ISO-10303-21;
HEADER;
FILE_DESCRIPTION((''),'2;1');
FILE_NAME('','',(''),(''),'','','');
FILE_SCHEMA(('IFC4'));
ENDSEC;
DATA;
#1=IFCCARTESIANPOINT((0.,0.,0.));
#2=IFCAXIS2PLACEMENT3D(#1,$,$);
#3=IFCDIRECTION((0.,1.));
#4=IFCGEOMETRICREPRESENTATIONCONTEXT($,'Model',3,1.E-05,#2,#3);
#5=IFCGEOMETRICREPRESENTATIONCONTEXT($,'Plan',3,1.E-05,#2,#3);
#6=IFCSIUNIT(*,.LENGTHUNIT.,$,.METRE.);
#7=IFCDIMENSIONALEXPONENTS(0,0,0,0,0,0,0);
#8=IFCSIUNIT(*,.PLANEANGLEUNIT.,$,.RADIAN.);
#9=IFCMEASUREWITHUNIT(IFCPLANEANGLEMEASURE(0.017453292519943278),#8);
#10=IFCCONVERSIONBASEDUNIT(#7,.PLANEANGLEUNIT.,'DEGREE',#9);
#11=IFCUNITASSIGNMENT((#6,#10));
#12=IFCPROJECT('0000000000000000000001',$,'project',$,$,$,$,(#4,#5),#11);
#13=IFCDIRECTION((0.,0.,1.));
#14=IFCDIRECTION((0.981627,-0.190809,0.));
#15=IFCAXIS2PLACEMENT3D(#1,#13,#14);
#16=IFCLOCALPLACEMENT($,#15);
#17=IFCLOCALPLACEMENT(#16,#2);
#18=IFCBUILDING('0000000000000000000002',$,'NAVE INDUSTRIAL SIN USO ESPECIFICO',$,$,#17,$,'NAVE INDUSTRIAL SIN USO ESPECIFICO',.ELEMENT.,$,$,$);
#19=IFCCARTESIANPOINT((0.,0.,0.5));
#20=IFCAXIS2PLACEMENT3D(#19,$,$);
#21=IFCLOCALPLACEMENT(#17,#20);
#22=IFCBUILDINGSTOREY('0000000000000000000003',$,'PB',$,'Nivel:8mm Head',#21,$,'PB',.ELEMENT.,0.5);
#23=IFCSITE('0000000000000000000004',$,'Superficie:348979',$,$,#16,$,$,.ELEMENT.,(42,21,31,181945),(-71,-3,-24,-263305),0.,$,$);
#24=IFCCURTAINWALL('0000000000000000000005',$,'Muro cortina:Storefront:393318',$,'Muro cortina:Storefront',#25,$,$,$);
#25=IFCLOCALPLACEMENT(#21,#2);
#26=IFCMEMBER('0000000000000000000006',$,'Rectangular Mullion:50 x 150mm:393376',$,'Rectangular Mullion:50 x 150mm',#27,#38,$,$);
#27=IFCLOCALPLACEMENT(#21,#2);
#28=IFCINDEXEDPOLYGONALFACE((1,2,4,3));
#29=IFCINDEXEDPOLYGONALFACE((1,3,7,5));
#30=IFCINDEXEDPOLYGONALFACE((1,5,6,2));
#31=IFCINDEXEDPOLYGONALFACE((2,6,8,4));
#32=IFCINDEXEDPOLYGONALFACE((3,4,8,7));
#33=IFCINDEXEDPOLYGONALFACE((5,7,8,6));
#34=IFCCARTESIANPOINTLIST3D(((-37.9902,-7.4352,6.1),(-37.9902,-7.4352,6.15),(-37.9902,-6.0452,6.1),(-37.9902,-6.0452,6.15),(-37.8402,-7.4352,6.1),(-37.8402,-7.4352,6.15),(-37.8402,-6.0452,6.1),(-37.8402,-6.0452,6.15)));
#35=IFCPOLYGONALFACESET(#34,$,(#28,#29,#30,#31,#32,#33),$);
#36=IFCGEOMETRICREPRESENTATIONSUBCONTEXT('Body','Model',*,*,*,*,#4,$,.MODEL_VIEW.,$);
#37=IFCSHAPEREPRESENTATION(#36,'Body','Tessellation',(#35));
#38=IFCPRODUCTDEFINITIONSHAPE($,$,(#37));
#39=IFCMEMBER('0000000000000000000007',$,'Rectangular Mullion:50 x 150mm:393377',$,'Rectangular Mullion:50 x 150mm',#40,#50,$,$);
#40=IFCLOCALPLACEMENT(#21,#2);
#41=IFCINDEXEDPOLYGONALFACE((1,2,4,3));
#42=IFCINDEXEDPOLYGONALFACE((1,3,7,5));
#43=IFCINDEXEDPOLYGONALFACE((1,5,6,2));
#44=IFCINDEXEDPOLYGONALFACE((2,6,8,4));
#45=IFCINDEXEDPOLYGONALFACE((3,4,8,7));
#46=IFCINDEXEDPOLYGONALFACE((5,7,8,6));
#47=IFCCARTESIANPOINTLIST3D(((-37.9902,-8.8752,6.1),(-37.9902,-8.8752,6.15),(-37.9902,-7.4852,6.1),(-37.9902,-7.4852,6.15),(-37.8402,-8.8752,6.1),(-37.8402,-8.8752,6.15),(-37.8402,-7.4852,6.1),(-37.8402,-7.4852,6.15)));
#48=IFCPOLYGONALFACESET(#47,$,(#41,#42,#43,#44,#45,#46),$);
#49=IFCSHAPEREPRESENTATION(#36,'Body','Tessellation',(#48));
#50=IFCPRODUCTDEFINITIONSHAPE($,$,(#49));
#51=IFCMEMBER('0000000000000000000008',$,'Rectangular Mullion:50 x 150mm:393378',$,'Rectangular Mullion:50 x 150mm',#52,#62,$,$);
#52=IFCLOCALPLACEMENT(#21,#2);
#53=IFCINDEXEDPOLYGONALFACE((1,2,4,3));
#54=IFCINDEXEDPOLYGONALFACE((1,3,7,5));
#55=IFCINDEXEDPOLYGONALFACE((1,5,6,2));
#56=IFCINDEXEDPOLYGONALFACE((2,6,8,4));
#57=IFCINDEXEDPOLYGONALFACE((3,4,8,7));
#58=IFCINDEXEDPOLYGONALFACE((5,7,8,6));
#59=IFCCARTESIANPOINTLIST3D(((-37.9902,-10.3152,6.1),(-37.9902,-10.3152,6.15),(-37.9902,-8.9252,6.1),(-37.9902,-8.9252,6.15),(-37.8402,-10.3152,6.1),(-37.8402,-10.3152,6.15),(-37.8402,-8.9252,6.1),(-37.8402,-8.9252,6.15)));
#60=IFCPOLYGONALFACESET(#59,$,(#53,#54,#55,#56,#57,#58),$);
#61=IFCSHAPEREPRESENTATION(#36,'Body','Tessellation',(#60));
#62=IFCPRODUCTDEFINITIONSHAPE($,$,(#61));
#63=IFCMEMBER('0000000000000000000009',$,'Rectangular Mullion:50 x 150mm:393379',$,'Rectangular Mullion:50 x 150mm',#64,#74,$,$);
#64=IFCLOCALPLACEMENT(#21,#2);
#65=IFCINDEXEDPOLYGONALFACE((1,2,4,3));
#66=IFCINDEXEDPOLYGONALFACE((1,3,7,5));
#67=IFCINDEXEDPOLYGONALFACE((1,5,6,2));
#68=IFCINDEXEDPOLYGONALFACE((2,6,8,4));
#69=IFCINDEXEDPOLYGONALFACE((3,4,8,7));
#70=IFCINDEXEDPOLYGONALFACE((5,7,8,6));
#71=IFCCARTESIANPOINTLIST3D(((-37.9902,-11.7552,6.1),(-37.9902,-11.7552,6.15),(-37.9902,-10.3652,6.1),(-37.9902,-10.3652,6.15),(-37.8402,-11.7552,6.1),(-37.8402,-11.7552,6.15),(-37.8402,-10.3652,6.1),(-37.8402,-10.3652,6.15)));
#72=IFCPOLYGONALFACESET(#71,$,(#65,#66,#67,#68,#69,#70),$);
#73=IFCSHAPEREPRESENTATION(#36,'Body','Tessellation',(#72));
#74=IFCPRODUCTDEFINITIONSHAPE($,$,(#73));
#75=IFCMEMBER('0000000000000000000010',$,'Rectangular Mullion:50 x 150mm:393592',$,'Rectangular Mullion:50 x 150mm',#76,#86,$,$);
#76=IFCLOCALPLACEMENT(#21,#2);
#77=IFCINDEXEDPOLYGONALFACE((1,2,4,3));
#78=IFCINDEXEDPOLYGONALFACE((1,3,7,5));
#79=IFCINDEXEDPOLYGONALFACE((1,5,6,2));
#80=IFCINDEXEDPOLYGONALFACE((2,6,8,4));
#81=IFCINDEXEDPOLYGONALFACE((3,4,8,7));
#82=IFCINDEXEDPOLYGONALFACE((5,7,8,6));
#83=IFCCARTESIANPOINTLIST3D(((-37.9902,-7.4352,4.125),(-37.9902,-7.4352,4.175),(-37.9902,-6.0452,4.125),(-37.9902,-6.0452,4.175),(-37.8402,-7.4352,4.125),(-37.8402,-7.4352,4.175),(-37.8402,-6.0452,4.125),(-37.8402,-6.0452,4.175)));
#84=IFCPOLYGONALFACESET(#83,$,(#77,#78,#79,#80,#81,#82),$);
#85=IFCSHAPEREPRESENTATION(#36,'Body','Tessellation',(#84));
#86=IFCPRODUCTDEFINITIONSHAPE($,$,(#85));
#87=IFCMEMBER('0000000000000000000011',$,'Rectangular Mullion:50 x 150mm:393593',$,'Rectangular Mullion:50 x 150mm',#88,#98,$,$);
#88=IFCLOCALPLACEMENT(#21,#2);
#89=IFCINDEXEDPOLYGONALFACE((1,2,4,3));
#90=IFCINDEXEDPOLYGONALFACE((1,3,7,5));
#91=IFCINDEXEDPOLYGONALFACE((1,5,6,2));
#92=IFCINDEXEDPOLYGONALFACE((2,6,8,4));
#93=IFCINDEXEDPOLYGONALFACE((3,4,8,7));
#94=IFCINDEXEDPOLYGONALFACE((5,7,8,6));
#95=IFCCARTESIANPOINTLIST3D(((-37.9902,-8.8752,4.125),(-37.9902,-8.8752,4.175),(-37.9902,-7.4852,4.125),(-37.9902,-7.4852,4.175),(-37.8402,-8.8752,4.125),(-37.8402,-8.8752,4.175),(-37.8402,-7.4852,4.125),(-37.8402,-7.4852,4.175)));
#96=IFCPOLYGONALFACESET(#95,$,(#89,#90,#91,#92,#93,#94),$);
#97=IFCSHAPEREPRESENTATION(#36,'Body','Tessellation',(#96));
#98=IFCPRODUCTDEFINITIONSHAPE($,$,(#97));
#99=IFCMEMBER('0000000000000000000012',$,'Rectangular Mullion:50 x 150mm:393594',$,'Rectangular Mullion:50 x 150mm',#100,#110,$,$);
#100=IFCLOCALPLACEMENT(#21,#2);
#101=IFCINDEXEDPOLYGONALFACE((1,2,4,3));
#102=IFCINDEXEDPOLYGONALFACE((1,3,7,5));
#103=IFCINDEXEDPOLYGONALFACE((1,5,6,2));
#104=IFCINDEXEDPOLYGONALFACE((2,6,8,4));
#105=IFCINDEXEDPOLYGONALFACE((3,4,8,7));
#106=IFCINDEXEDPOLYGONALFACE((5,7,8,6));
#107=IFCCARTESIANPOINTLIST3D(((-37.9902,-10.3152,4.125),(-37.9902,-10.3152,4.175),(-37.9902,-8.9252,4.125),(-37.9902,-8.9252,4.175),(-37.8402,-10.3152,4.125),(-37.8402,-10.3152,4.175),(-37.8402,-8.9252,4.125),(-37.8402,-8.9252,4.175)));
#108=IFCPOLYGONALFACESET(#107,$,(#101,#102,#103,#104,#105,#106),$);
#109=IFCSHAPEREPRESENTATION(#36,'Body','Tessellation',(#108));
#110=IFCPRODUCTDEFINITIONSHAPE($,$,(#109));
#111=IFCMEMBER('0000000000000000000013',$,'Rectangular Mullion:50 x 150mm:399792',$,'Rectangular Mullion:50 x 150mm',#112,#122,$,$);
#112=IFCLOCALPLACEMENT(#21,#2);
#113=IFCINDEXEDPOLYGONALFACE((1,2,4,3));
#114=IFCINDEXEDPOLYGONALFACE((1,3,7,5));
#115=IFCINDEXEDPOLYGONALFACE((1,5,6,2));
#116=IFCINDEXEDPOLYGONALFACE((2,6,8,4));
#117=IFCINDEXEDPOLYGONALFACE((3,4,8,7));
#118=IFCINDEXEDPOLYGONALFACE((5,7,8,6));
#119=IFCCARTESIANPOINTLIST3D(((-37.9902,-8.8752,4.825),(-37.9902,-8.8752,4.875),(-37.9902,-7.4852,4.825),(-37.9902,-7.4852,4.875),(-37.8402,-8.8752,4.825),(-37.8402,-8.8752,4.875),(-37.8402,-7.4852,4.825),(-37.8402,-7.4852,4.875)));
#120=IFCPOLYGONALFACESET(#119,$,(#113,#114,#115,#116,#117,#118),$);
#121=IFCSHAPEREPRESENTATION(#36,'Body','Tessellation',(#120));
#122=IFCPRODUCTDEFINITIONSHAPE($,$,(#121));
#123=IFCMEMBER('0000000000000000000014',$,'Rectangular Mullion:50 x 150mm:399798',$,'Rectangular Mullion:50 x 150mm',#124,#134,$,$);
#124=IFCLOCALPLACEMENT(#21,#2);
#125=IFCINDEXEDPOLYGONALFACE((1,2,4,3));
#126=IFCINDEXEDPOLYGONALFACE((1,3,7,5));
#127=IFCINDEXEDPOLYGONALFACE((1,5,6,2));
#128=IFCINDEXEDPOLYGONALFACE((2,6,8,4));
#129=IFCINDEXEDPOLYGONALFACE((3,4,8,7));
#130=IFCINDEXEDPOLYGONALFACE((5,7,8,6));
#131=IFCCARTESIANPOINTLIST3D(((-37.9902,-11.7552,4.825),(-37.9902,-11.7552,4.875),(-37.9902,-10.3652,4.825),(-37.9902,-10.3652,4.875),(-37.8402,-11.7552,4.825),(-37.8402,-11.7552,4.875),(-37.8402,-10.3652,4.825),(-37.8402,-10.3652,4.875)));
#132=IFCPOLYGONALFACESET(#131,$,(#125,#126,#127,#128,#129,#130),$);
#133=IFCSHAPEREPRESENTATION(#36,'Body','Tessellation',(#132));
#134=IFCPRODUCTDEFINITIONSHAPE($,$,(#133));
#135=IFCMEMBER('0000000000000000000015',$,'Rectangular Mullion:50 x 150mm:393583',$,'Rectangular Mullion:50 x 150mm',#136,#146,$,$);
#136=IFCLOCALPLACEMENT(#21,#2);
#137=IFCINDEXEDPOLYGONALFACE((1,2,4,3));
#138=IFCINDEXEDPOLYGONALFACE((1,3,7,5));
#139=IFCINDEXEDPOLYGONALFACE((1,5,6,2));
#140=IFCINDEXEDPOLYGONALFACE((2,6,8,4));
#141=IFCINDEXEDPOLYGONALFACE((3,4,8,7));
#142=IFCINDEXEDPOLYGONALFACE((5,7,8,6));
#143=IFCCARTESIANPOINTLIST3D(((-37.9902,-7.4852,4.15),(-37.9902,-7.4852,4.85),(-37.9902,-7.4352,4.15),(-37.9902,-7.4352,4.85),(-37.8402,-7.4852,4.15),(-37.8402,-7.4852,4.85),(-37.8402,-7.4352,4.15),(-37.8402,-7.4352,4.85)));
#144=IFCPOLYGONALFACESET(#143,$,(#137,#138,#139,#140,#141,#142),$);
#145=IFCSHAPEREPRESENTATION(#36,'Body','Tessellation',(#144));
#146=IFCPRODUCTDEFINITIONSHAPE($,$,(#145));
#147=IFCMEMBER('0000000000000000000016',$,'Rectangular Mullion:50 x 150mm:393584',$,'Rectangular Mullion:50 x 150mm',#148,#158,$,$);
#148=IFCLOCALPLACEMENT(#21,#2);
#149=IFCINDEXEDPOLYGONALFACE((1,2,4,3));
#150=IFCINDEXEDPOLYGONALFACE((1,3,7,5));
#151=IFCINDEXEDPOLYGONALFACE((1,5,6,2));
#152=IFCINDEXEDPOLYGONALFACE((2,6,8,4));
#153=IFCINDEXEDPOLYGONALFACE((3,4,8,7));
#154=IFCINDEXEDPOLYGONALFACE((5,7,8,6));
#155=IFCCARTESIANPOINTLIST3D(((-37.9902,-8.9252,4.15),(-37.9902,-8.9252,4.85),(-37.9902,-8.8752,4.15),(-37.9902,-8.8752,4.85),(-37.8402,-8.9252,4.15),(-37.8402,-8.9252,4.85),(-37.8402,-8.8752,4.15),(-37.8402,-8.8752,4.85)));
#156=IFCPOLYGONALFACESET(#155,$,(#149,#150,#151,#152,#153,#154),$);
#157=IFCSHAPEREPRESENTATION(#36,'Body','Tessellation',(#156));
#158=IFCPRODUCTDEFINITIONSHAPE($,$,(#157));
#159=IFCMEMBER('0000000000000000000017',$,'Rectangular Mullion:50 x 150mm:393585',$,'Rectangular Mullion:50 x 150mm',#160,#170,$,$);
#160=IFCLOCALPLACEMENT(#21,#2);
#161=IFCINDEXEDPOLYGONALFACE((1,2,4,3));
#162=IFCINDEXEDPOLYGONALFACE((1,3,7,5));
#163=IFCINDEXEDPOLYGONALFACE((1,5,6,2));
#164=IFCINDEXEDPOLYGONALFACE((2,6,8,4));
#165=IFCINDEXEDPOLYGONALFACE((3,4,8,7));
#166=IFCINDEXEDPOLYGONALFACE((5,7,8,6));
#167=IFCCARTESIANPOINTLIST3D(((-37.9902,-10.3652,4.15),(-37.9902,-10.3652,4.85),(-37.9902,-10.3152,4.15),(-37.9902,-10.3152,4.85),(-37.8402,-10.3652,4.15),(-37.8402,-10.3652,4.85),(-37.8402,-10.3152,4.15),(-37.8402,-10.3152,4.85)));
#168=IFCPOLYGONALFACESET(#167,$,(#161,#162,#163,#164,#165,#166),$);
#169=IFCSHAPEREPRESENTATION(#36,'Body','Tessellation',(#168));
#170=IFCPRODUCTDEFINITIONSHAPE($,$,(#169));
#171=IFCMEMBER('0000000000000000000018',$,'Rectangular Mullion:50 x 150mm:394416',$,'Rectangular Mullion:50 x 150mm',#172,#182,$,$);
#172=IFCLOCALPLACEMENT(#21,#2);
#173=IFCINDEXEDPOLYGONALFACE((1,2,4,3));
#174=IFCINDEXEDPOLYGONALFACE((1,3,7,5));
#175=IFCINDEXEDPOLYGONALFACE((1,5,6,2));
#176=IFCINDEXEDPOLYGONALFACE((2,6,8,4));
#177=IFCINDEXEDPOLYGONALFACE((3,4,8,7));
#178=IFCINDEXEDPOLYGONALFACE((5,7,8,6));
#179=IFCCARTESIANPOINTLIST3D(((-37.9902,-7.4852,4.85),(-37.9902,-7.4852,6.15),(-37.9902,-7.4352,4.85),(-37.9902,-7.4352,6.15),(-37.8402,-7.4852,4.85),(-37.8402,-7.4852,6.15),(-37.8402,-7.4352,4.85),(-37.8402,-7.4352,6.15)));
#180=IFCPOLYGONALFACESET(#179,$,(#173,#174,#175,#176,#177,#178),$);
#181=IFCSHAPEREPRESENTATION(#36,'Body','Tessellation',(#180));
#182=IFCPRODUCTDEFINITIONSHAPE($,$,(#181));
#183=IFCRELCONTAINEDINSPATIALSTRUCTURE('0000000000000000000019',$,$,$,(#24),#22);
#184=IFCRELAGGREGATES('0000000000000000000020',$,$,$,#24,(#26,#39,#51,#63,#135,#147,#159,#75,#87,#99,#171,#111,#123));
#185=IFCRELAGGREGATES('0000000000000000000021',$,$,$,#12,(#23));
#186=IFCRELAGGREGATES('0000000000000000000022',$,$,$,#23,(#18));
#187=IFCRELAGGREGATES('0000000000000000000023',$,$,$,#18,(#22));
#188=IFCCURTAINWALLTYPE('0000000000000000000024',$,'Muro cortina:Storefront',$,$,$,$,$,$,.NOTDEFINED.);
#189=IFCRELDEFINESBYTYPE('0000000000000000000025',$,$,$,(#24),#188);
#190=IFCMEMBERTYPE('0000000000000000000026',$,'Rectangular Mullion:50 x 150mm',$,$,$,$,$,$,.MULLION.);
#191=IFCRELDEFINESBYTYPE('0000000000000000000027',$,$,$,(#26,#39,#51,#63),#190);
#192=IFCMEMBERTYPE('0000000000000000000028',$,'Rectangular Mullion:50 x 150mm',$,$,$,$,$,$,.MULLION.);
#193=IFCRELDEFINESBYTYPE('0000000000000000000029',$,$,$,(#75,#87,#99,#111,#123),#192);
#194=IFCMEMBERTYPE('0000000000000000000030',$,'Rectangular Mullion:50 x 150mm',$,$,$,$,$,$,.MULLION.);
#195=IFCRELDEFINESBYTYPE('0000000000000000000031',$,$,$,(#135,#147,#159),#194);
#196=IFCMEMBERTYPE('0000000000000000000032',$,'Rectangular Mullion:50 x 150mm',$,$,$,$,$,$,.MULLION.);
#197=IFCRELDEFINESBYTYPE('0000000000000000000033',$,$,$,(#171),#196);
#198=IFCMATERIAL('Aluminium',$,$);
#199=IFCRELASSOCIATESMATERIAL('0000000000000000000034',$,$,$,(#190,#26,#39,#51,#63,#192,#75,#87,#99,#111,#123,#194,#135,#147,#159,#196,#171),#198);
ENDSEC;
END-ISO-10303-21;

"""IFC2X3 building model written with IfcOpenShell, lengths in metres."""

from ifc_helpers import new_model, entity, si_unit, converted_unit, direction, frame, origin, origin_2d_with_axis, place, context, subcontext, project, spatial, rectangle, extrude, source, transform, mapped, material, type_object, type_shapes, element, aggregate, save


model = new_model("IFC2X3")

# Units and contexts
model_context = context("Model", 3, precision=1e-05, world=origin(), true_north=direction((0.0, 1.0)))
plan_context = context("Plan", 3, precision=1e-05, world=origin(), true_north=direction((0.0, 1.0)))
body_context = subcontext(model_context, "Body", "Model", "MODEL_VIEW")
ifc_project = project(units=[si_unit("LENGTHUNIT", "METRE"), converted_unit("PLANEANGLEUNIT", "DEGREE", entity("IfcPlaneAngleMeasure", 0.017453292519943278), si_unit("PLANEANGLEUNIT", "RADIAN"), dimensions=[0, 0, 0, 0, 0, 0, 0])], contexts=[model_context, plan_context])

# Site, building, storey
site_placement = place(None, frame((0.0, 0.0, 0.0), z_axis=(0.0, 0.0, 1.0), x_axis=(0.981627, -0.190809, 0.0)))
site = spatial("IfcSite", under=ifc_project, at=site_placement, Name="Superficie:348979", CompositionType="ELEMENT", RefLatitude=(42, 21, 31, 181945), RefLongitude=(-71, -3, -24, -263305), RefElevation=0.0)
building_placement = place(site_placement, origin())
building = spatial("IfcBuilding", under=site, at=building_placement, Name="NAVE INDUSTRIAL SIN USO ESPECIFICO", LongName="NAVE INDUSTRIAL SIN USO ESPECIFICO", CompositionType="ELEMENT")
storey_placement = place(building_placement, frame((0.0, 0.0, 0.5)))
storey = spatial("IfcBuildingStorey", under=building, at=storey_placement, Name="PB", ObjectType="Nivel:8mm Head", LongName="PB", CompositionType="ELEMENT", Elevation=0.5)

# Curtain wall, members
curtain_wall_type = type_object("IfcCurtainWallType", Name="Muro cortina:Storefront", PredefinedType="NOTDEFINED")
curtain_wall_placement = place(storey_placement, frame((0.0, 0.0, -0.5)))
curtain_wall = element("IfcCurtainWall", 1, at=curtain_wall_placement, inside=storey, type_object=curtain_wall_type, Name="Muro cortina:Storefront:393318", ObjectType="Muro cortina:Storefront")
ifc_material_1 = material(Name="Aluminium")
member_type_1 = type_object("IfcMemberType", Name="Rectangular Mullion:50 x 150mm", PredefinedType="MULLION", material=ifc_material_1)
shared_shape_1 = source(origin(), body_context, "Body", "SweptSolid", [
    extrude(rectangle(XDim=0.05, YDim=0.15, at=origin_2d_with_axis()), frame((-0.025, 0.0, -1.39), z_axis=(0.0, 0.0, 1.0), x_axis=(-1.0, 0.0, 0.0)), (0.0, 0.0, 1.0), 1.39),
])
type_shapes(member_type_1, [shared_shape_1])
member_1_placement = place(curtain_wall_placement, frame((-37.9152, -7.4352, 6.65), z_axis=(0.0, -1.0, 0.0), x_axis=(0.0, 0.0, 1.0)))
member_1 = element("IfcMember", 2, at=member_1_placement, type_object=member_type_1, material=ifc_material_1, Name="Rectangular Mullion:50 x 150mm:393376", ObjectType="Rectangular Mullion:50 x 150mm", context=body_context, shape_type="MappedRepresentation", body=[
    mapped(shared_shape_1, transform((0.0, 0.0, 0.0), scale=1.0)),
])
member_2_placement = place(curtain_wall_placement, frame((-37.9152, -8.8752, 6.65), z_axis=(0.0, -1.0, 0.0), x_axis=(0.0, 0.0, 1.0)))
member_2 = element("IfcMember", 3, at=member_2_placement, type_object=member_type_1, material=ifc_material_1, Name="Rectangular Mullion:50 x 150mm:393377", ObjectType="Rectangular Mullion:50 x 150mm", context=body_context, shape_type="MappedRepresentation", body=[
    mapped(shared_shape_1, transform((0.0, 0.0, 0.0), scale=1.0)),
])
member_3_placement = place(curtain_wall_placement, frame((-37.9152, -10.3152, 6.65), z_axis=(0.0, -1.0, 0.0), x_axis=(0.0, 0.0, 1.0)))
member_3 = element("IfcMember", 4, at=member_3_placement, type_object=member_type_1, material=ifc_material_1, Name="Rectangular Mullion:50 x 150mm:393378", ObjectType="Rectangular Mullion:50 x 150mm", context=body_context, shape_type="MappedRepresentation", body=[
    mapped(shared_shape_1, transform((0.0, 0.0, 0.0), scale=1.0)),
])
member_4_placement = place(curtain_wall_placement, frame((-37.9152, -11.7552, 6.65), z_axis=(0.0, -1.0, 0.0), x_axis=(0.0, 0.0, 1.0)))
member_4 = element("IfcMember", 5, at=member_4_placement, type_object=member_type_1, material=ifc_material_1, Name="Rectangular Mullion:50 x 150mm:393379", ObjectType="Rectangular Mullion:50 x 150mm", context=body_context, shape_type="MappedRepresentation", body=[
    mapped(shared_shape_1, transform((0.0, 0.0, 0.0), scale=1.0)),
])
member_type_2 = type_object("IfcMemberType", Name="Rectangular Mullion:50 x 150mm", PredefinedType="MULLION", material=ifc_material_1)
shared_shape_2 = source(origin(), body_context, "Body", "SweptSolid", [
    extrude(rectangle(XDim=0.05, YDim=0.15, at=origin_2d_with_axis()), frame((0.0, 0.0, -1.39), z_axis=(0.0, 0.0, 1.0), x_axis=(-1.0, 0.0, 0.0)), (0.0, 0.0, 1.0), 1.39),
])
type_shapes(member_type_2, [shared_shape_2])
member_5_placement = place(curtain_wall_placement, frame((-37.9152, -7.4352, 4.65), z_axis=(0.0, -1.0, 0.0), x_axis=(0.0, 0.0, 1.0)))
member_5 = element("IfcMember", 6, at=member_5_placement, type_object=member_type_2, material=ifc_material_1, Name="Rectangular Mullion:50 x 150mm:393592", ObjectType="Rectangular Mullion:50 x 150mm", context=body_context, shape_type="MappedRepresentation", body=[
    mapped(shared_shape_2, transform((0.0, 0.0, 0.0), scale=1.0)),
])
member_6_placement = place(curtain_wall_placement, frame((-37.9152, -8.8752, 4.65), z_axis=(0.0, -1.0, 0.0), x_axis=(0.0, 0.0, 1.0)))
member_6 = element("IfcMember", 7, at=member_6_placement, type_object=member_type_2, material=ifc_material_1, Name="Rectangular Mullion:50 x 150mm:393593", ObjectType="Rectangular Mullion:50 x 150mm", context=body_context, shape_type="MappedRepresentation", body=[
    mapped(shared_shape_2, transform((0.0, 0.0, 0.0), scale=1.0)),
])
member_7_placement = place(curtain_wall_placement, frame((-37.9152, -10.3152, 4.65), z_axis=(0.0, -1.0, 0.0), x_axis=(0.0, 0.0, 1.0)))
member_7 = element("IfcMember", 8, at=member_7_placement, type_object=member_type_2, material=ifc_material_1, Name="Rectangular Mullion:50 x 150mm:393594", ObjectType="Rectangular Mullion:50 x 150mm", context=body_context, shape_type="MappedRepresentation", body=[
    mapped(shared_shape_2, transform((0.0, 0.0, 0.0), scale=1.0)),
])
member_8_placement = place(curtain_wall_placement, frame((-37.9152, -8.8752, 5.35), z_axis=(0.0, -1.0, 0.0), x_axis=(0.0, 0.0, 1.0)))
member_8 = element("IfcMember", 9, at=member_8_placement, type_object=member_type_2, material=ifc_material_1, Name="Rectangular Mullion:50 x 150mm:399792", ObjectType="Rectangular Mullion:50 x 150mm", context=body_context, shape_type="MappedRepresentation", body=[
    mapped(shared_shape_2, transform((0.0, 0.0, 0.0), scale=1.0)),
])
member_9_placement = place(curtain_wall_placement, frame((-37.9152, -11.7552, 5.35), z_axis=(0.0, -1.0, 0.0), x_axis=(0.0, 0.0, 1.0)))
member_9 = element("IfcMember", 10, at=member_9_placement, type_object=member_type_2, material=ifc_material_1, Name="Rectangular Mullion:50 x 150mm:399798", ObjectType="Rectangular Mullion:50 x 150mm", context=body_context, shape_type="MappedRepresentation", body=[
    mapped(shared_shape_2, transform((0.0, 0.0, 0.0), scale=1.0)),
])
member_type_3 = type_object("IfcMemberType", Name="Rectangular Mullion:50 x 150mm", PredefinedType="MULLION", material=ifc_material_1)
shared_shape_3 = source(origin(), body_context, "Body", "SweptSolid", [
    extrude(rectangle(XDim=0.05, YDim=0.15, at=origin_2d_with_axis()), frame((0.0, 0.0, -0.7), z_axis=(0.0, 0.0, 1.0), x_axis=(-1.0, 0.0, 0.0)), (0.0, 0.0, 1.0), 0.7),
])
type_shapes(member_type_3, [shared_shape_3])
member_10_placement = place(curtain_wall_placement, frame((-37.9152, -7.4602, 4.65), z_axis=(0.0, 0.0, -1.0), x_axis=(0.0, -1.0, 0.0)))
member_10 = element("IfcMember", 11, at=member_10_placement, type_object=member_type_3, material=ifc_material_1, Name="Rectangular Mullion:50 x 150mm:393583", ObjectType="Rectangular Mullion:50 x 150mm", context=body_context, shape_type="MappedRepresentation", body=[
    mapped(shared_shape_3, transform((0.0, 0.0, 0.0), scale=1.0)),
])
member_11_placement = place(curtain_wall_placement, frame((-37.9152, -8.9002, 4.65), z_axis=(0.0, 0.0, -1.0), x_axis=(0.0, -1.0, 0.0)))
member_11 = element("IfcMember", 12, at=member_11_placement, type_object=member_type_3, material=ifc_material_1, Name="Rectangular Mullion:50 x 150mm:393584", ObjectType="Rectangular Mullion:50 x 150mm", context=body_context, shape_type="MappedRepresentation", body=[
    mapped(shared_shape_3, transform((0.0, 0.0, 0.0), scale=1.0)),
])
member_12_placement = place(curtain_wall_placement, frame((-37.9152, -10.3402, 4.65), z_axis=(0.0, 0.0, -1.0), x_axis=(0.0, -1.0, 0.0)))
member_12 = element("IfcMember", 13, at=member_12_placement, type_object=member_type_3, material=ifc_material_1, Name="Rectangular Mullion:50 x 150mm:393585", ObjectType="Rectangular Mullion:50 x 150mm", context=body_context, shape_type="MappedRepresentation", body=[
    mapped(shared_shape_3, transform((0.0, 0.0, 0.0), scale=1.0)),
])
member_type_4 = type_object("IfcMemberType", Name="Rectangular Mullion:50 x 150mm", PredefinedType="MULLION", material=ifc_material_1)
shared_shape_4 = source(origin(), body_context, "Body", "SweptSolid", [
    extrude(rectangle(XDim=0.05, YDim=0.15, at=origin_2d_with_axis()), frame((0.0, 0.0, -1.3), z_axis=(0.0, 0.0, 1.0), x_axis=(-1.0, 0.0, 0.0)), (0.0, 0.0, 1.0), 1.3),
])
type_shapes(member_type_4, [shared_shape_4])
member_13_placement = place(curtain_wall_placement, frame((-37.9152, -7.4602, 5.35), z_axis=(0.0, 0.0, -1.0), x_axis=(0.0, -1.0, 0.0)))
member_13 = element("IfcMember", 14, at=member_13_placement, type_object=member_type_4, material=ifc_material_1, Name="Rectangular Mullion:50 x 150mm:394416", ObjectType="Rectangular Mullion:50 x 150mm", context=body_context, shape_type="MappedRepresentation", body=[
    mapped(shared_shape_4, transform((0.0, 0.0, 0.0), scale=1.0)),
])
aggregate(curtain_wall, [member_1, member_2, member_3, member_4, member_10, member_11, member_12, member_5, member_6, member_7, member_13, member_8, member_9])

save(model, "model.ifc")
